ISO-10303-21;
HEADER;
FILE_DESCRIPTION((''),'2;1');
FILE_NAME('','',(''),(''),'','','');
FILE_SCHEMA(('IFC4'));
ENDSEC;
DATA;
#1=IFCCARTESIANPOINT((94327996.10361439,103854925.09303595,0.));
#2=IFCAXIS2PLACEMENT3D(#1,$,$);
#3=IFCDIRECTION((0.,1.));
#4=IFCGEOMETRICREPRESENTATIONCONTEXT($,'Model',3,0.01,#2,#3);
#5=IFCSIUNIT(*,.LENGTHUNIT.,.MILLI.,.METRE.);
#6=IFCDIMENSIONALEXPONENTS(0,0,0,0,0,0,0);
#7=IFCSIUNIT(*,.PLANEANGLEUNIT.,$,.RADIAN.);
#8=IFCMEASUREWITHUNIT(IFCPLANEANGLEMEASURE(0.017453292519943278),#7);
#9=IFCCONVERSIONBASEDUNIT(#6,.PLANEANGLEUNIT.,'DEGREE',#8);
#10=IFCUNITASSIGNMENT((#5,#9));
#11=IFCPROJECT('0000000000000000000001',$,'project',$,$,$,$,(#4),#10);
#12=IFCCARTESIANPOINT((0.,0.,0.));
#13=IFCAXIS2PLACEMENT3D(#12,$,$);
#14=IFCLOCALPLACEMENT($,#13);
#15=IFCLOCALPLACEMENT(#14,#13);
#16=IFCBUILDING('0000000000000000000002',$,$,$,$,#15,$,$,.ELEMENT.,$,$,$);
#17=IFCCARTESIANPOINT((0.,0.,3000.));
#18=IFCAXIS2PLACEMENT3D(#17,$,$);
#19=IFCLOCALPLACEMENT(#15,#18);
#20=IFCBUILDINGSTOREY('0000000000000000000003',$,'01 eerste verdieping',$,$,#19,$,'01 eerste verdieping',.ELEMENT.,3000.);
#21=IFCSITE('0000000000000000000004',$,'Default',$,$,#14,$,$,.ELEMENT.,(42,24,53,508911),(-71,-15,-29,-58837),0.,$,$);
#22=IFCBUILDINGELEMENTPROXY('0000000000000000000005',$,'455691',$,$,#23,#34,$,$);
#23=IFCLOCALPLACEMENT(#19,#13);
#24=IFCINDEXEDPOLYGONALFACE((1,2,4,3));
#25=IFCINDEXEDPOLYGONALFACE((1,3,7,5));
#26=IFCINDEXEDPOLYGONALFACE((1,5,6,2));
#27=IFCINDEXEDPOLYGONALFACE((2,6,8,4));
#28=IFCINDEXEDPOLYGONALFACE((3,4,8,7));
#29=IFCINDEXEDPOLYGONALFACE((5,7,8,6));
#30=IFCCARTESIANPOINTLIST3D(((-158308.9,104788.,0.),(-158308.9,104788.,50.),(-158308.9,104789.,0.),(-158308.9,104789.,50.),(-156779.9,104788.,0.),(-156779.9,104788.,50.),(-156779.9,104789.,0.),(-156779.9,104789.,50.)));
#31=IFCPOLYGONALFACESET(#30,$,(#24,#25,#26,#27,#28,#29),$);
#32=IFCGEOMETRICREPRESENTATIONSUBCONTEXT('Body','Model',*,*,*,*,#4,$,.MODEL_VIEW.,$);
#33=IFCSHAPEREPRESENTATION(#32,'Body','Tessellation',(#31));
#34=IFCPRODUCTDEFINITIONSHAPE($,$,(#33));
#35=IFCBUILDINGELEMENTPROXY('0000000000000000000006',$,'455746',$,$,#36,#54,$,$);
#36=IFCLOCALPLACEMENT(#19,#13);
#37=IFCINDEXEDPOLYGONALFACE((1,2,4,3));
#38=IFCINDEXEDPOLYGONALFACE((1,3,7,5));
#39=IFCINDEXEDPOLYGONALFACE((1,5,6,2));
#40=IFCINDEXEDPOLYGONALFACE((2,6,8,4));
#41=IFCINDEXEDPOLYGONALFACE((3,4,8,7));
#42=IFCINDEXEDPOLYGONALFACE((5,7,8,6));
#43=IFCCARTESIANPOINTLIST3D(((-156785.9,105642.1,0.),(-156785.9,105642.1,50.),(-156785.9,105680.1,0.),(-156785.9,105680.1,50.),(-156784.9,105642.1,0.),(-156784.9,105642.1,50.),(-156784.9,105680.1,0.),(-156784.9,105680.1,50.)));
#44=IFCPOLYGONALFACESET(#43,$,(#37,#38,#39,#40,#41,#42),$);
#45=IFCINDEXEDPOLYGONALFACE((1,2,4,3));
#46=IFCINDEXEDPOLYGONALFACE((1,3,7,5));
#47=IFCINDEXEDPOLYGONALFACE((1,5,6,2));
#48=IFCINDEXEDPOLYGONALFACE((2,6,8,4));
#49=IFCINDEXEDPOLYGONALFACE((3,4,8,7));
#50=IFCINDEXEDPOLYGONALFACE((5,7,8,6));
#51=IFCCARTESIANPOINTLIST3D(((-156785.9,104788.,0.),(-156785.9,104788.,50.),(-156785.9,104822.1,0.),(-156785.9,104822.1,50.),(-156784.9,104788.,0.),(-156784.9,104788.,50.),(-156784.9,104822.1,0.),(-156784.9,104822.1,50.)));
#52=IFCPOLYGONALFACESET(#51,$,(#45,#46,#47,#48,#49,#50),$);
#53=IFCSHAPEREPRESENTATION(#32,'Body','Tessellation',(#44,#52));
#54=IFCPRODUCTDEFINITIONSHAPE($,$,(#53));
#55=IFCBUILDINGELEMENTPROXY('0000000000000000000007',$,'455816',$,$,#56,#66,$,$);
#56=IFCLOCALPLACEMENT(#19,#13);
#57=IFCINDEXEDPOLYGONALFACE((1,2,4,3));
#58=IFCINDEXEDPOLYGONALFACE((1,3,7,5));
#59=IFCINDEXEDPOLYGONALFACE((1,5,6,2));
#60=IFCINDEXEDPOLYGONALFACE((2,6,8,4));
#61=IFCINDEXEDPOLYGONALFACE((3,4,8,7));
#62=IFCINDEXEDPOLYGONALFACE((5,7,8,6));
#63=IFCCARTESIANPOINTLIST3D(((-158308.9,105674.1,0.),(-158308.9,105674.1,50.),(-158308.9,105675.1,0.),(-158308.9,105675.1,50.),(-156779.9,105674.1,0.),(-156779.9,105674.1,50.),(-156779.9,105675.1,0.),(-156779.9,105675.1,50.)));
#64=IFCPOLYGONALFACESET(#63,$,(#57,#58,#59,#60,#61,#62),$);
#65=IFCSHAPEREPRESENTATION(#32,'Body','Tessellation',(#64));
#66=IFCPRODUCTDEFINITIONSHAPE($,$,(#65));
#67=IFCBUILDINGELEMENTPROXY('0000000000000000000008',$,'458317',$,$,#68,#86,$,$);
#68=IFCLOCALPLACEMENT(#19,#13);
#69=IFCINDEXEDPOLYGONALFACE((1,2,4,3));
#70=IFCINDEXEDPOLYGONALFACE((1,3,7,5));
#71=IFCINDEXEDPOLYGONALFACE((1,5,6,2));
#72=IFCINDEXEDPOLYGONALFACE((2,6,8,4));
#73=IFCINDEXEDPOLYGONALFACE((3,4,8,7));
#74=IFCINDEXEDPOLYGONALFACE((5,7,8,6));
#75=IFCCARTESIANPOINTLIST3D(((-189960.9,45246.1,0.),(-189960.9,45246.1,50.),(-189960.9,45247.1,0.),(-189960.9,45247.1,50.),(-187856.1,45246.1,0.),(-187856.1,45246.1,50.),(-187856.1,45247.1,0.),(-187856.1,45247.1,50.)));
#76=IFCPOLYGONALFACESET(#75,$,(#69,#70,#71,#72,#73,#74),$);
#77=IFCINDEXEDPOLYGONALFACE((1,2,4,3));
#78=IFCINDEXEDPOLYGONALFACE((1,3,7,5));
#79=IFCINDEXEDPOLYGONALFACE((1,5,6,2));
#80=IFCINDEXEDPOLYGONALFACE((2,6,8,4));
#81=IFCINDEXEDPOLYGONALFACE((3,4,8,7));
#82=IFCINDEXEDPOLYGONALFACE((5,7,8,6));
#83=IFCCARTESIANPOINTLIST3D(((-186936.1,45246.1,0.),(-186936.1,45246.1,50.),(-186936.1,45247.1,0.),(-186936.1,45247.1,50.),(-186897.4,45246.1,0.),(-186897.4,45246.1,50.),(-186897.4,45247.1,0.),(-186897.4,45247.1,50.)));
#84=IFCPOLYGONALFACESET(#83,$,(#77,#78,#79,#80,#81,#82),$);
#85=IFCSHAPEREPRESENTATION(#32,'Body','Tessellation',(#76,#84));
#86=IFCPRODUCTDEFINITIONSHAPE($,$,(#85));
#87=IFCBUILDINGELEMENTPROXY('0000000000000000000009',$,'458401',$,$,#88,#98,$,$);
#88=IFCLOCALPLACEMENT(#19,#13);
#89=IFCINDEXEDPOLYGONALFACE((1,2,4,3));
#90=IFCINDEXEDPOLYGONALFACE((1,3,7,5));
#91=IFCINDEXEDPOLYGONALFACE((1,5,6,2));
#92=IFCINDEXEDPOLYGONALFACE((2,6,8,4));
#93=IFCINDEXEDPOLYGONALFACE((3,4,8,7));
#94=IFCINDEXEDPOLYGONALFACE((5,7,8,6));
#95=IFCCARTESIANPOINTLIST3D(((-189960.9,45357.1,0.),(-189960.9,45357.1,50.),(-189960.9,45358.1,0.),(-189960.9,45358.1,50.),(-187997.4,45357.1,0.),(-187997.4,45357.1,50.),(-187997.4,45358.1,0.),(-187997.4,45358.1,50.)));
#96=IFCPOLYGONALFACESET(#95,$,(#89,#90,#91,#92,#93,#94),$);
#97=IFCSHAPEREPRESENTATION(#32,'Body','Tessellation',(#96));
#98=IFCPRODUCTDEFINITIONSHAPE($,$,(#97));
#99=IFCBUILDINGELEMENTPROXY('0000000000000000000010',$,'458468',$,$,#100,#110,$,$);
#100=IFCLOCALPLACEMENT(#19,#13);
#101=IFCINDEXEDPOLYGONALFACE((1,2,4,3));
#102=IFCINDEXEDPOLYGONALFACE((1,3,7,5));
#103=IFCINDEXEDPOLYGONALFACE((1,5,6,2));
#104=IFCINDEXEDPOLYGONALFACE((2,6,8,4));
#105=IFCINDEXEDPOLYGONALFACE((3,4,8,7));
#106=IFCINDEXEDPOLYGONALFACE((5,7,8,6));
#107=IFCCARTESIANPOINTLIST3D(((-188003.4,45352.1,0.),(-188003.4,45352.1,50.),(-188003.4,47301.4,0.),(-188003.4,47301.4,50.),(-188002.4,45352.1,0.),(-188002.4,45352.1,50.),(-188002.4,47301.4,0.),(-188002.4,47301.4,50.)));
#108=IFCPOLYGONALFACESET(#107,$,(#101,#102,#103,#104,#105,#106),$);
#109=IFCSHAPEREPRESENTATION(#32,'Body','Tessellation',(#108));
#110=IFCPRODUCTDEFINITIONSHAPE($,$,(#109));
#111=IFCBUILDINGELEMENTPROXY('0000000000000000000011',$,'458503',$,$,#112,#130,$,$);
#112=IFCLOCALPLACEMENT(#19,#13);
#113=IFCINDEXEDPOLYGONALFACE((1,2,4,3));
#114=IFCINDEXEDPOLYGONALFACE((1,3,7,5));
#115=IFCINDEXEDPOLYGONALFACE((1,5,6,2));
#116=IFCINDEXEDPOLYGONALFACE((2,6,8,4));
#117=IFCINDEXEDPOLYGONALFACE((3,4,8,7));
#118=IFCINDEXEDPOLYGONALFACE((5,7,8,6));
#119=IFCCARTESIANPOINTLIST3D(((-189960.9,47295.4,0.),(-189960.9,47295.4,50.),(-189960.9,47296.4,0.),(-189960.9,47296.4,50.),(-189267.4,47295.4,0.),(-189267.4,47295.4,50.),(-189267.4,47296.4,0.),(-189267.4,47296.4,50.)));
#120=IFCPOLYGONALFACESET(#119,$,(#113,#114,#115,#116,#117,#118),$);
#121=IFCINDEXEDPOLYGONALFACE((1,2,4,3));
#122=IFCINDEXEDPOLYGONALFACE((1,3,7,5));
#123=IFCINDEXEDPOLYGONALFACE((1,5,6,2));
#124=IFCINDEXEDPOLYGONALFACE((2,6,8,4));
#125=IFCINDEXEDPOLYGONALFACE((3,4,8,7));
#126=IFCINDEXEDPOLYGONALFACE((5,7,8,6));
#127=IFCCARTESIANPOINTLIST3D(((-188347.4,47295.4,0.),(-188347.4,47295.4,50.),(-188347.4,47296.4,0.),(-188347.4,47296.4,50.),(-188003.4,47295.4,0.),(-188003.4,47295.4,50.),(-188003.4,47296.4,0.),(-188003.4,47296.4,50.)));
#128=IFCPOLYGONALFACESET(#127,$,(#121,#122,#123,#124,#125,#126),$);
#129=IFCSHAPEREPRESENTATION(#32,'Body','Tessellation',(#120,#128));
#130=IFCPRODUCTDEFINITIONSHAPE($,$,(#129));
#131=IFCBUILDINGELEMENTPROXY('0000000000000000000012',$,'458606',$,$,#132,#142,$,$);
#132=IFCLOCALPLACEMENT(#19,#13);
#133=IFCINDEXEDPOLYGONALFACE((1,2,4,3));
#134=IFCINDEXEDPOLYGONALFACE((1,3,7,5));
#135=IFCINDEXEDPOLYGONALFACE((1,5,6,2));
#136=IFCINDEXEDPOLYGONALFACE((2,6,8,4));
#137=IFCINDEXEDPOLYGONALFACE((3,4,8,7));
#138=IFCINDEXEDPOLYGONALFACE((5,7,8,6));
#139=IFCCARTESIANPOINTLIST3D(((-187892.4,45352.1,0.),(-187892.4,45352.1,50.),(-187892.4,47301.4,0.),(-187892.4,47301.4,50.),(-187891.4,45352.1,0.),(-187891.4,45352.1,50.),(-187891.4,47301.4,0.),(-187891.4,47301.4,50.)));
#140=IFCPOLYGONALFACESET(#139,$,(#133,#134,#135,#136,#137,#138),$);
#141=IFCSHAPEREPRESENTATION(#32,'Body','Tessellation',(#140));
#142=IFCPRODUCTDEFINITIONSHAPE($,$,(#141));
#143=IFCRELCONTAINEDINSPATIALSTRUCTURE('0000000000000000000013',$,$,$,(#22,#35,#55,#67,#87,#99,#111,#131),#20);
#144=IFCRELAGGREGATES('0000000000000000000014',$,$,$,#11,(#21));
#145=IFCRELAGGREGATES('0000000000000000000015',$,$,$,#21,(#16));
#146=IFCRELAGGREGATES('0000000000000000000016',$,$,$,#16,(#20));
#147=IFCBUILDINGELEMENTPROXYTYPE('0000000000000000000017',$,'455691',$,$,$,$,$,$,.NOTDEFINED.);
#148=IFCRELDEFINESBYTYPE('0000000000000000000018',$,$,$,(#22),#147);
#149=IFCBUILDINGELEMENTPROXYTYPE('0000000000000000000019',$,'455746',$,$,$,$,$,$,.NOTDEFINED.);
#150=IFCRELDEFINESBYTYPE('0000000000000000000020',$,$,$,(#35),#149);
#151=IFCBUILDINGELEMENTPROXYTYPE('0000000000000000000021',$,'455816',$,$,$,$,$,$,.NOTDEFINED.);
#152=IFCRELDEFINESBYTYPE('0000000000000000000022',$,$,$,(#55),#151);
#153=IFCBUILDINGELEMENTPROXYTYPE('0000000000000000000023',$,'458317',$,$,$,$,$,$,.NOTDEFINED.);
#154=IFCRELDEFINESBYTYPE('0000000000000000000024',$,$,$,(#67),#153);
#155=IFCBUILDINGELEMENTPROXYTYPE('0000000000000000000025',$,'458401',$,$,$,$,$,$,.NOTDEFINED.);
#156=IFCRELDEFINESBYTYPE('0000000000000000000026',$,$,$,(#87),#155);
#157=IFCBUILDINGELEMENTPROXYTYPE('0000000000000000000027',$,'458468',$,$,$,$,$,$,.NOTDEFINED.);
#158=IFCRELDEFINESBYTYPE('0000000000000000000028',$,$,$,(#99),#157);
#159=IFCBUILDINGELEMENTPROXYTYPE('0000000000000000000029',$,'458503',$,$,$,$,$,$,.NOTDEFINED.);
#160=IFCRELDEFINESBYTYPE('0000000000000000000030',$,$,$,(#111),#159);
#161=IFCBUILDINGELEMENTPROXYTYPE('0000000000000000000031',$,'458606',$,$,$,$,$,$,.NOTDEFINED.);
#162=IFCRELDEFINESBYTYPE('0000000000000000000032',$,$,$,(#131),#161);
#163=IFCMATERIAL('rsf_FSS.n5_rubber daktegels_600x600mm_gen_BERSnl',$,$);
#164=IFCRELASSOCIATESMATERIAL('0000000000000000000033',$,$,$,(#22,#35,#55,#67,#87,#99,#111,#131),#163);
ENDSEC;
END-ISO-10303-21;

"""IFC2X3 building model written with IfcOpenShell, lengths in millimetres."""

from ifc_helpers import new_model, entity, si_unit, converted_unit, direction, frame, frame_2d, origin, origin_2d_with_axis, place, context, subcontext, project, spatial, rectangle, extrude, material, type_object, element, save


model = new_model("IFC2X3")

# Units and contexts
model_context = context("Model", 3, precision=0.01, world=frame((94327996.10361439, 103854925.09303595, 0.0)), true_north=direction((0.0, 1.0)))
body_context = subcontext(model_context, "Body", "Model", "MODEL_VIEW")
ifc_project = project(units=[si_unit("LENGTHUNIT", "METRE", prefix="MILLI"), converted_unit("PLANEANGLEUNIT", "DEGREE", entity("IfcPlaneAngleMeasure", 0.017453292519943278), si_unit("PLANEANGLEUNIT", "RADIAN"), dimensions=[0, 0, 0, 0, 0, 0, 0])], contexts=[model_context])

# Site, building, storey
site_placement = place(None, origin())
site = spatial("IfcSite", under=ifc_project, at=site_placement, Name="Default", CompositionType="ELEMENT", RefLatitude=(42, 24, 53, 508911), RefLongitude=(-71, -15, -29, -58837), RefElevation=0.0)
building_placement = place(site_placement, origin())
building = spatial("IfcBuilding", under=site, at=building_placement, CompositionType="ELEMENT")
storey_placement = place(building_placement, frame((0.0, 0.0, 3000.0)))
storey = spatial("IfcBuildingStorey", under=building, at=storey_placement, Name="01 eerste verdieping", LongName="01 eerste verdieping", CompositionType="ELEMENT", Elevation=3000.0)

# Building element proxies
ifc_material = material(Name="rsf_FSS.n5_rubber daktegels_600x600mm_gen_BERSnl")
building_element_proxy_type_1 = type_object("IfcBuildingElementProxyType", Name="455691", PredefinedType="NOTDEFINED")
proxy_1_placement = place(storey_placement, origin())
element("IfcBuildingElementProxy", 1, at=proxy_1_placement, inside=storey, type_object=building_element_proxy_type_1, material=ifc_material, Name="455691", context=body_context, shape_type="SweptSolid", body=[
    extrude(rectangle(XDim=1529.0, YDim=1.0, at=frame_2d((0.0, 0.0), x_axis=(1.0, 0.0))), frame((-157544.4, 104788.5, 0.0)), (0.0, 0.0, 1.0), 50.0),
])
building_element_proxy_type_2 = type_object("IfcBuildingElementProxyType", Name="455746", PredefinedType="NOTDEFINED")
proxy_2_placement = place(storey_placement, origin())
element("IfcBuildingElementProxy", 2, at=proxy_2_placement, inside=storey, type_object=building_element_proxy_type_2, material=ifc_material, Name="455746", context=body_context, shape_type="SweptSolid", body=[
    extrude(rectangle(XDim=38.0, YDim=1.0, at=frame_2d((0.0, 0.0), x_axis=(1.0, 0.0))), frame((-156785.4, 105661.1, 0.0), z_axis=(0.0, 0.0, 1.0), x_axis=(0.0, 1.0, 0.0)), (0.0, 0.0, 1.0), 50.0),
    extrude(rectangle(XDim=34.2, YDim=1.0, at=frame_2d((0.0, 0.0), x_axis=(1.0, 0.0))), frame((-156785.4, 104805.0, 0.0), z_axis=(0.0, 0.0, 1.0), x_axis=(0.0, 1.0, 0.0)), (0.0, 0.0, 1.0), 50.0),
])
building_element_proxy_type_3 = type_object("IfcBuildingElementProxyType", Name="455816", PredefinedType="NOTDEFINED")
proxy_3_placement = place(storey_placement, origin())
element("IfcBuildingElementProxy", 3, at=proxy_3_placement, inside=storey, type_object=building_element_proxy_type_3, material=ifc_material, Name="455816", context=body_context, shape_type="SweptSolid", body=[
    extrude(rectangle(XDim=1529.0, YDim=1.0, at=frame_2d((0.0, 0.0), x_axis=(1.0, 0.0))), frame((-157544.4, 105674.6, 0.0), z_axis=(0.0, 0.0, 1.0), x_axis=(-1.0, 0.0, 0.0)), (0.0, 0.0, 1.0), 50.0),
])
building_element_proxy_type_4 = type_object("IfcBuildingElementProxyType", Name="458317", PredefinedType="NOTDEFINED")
proxy_4_placement = place(storey_placement, origin())
element("IfcBuildingElementProxy", 4, at=proxy_4_placement, inside=storey, type_object=building_element_proxy_type_4, material=ifc_material, Name="458317", context=body_context, shape_type="SweptSolid", body=[
    extrude(rectangle(XDim=2104.7, YDim=1.0, at=frame_2d((0.0, 0.0), x_axis=(1.0, 0.0))), frame((-188908.5, 45246.6, 0.0), z_axis=(0.0, 0.0, 1.0), x_axis=(-1.0, 0.0, 0.0)), (0.0, 0.0, 1.0), 50.0),
    extrude(rectangle(XDim=38.7, YDim=1.0, at=frame_2d((0.0, 0.0), x_axis=(1.0, 0.0))), frame((-186916.8, 45246.6, 0.0), z_axis=(0.0, 0.0, 1.0), x_axis=(-1.0, 0.0, 0.0)), (0.0, 0.0, 1.0), 50.0),
])
building_element_proxy_type_5 = type_object("IfcBuildingElementProxyType", Name="458401", PredefinedType="NOTDEFINED")
proxy_5_placement = place(storey_placement, origin())
element("IfcBuildingElementProxy", 5, at=proxy_5_placement, inside=storey, type_object=building_element_proxy_type_5, material=ifc_material, Name="458401", context=body_context, shape_type="SweptSolid", body=[
    extrude(rectangle(XDim=1963.5, YDim=1.0, at=frame_2d((0.0, 0.0), x_axis=(1.0, 0.0))), frame((-188979.1, 45357.6, 0.0)), (0.0, 0.0, 1.0), 50.0),
])
building_element_proxy_type_6 = type_object("IfcBuildingElementProxyType", Name="458468", PredefinedType="NOTDEFINED")
proxy_6_placement = place(storey_placement, origin())
element("IfcBuildingElementProxy", 6, at=proxy_6_placement, inside=storey, type_object=building_element_proxy_type_6, material=ifc_material, Name="458468", context=body_context, shape_type="SweptSolid", body=[
    extrude(rectangle(XDim=1949.4, YDim=1.0, at=frame_2d((0.0, 0.0), x_axis=(1.0, 0.0))), frame((-188002.9, 46326.7, 0.0), z_axis=(0.0, 0.0, 1.0), x_axis=(0.0, 1.0, 0.0)), (0.0, 0.0, 1.0), 50.0),
])
building_element_proxy_type_7 = type_object("IfcBuildingElementProxyType", Name="458503", PredefinedType="NOTDEFINED")
proxy_7_placement = place(storey_placement, origin())
element("IfcBuildingElementProxy", 7, at=proxy_7_placement, inside=storey, type_object=building_element_proxy_type_7, material=ifc_material, Name="458503", context=body_context, shape_type="SweptSolid", body=[
    extrude(rectangle(XDim=693.5, YDim=1.0, at=origin_2d_with_axis()), frame((-189614.1, 47295.9, 0.0), z_axis=(0.0, 0.0, 1.0), x_axis=(-1.0, 0.0, 0.0)), (0.0, 0.0, 1.0), 50.0),
    extrude(rectangle(XDim=344.0, YDim=1.0, at=origin_2d_with_axis()), frame((-188175.4, 47295.9, 0.0), z_axis=(0.0, 0.0, 1.0), x_axis=(-1.0, 0.0, 0.0)), (0.0, 0.0, 1.0), 50.0),
])
building_element_proxy_type_8 = type_object("IfcBuildingElementProxyType", Name="458606", PredefinedType="NOTDEFINED")
proxy_8_placement = place(storey_placement, origin())
element("IfcBuildingElementProxy", 8, at=proxy_8_placement, inside=storey, type_object=building_element_proxy_type_8, material=ifc_material, Name="458606", context=body_context, shape_type="SweptSolid", body=[
    extrude(rectangle(XDim=1949.4, YDim=1.0, at=frame_2d((0.0, 0.0), x_axis=(1.0, 0.0))), frame((-187891.9, 46326.7, 0.0), z_axis=(0.0, 0.0, 1.0), x_axis=(0.0, -1.0, 0.0)), (0.0, 0.0, 1.0), 50.0),
])

save(model, "model.ifc")
